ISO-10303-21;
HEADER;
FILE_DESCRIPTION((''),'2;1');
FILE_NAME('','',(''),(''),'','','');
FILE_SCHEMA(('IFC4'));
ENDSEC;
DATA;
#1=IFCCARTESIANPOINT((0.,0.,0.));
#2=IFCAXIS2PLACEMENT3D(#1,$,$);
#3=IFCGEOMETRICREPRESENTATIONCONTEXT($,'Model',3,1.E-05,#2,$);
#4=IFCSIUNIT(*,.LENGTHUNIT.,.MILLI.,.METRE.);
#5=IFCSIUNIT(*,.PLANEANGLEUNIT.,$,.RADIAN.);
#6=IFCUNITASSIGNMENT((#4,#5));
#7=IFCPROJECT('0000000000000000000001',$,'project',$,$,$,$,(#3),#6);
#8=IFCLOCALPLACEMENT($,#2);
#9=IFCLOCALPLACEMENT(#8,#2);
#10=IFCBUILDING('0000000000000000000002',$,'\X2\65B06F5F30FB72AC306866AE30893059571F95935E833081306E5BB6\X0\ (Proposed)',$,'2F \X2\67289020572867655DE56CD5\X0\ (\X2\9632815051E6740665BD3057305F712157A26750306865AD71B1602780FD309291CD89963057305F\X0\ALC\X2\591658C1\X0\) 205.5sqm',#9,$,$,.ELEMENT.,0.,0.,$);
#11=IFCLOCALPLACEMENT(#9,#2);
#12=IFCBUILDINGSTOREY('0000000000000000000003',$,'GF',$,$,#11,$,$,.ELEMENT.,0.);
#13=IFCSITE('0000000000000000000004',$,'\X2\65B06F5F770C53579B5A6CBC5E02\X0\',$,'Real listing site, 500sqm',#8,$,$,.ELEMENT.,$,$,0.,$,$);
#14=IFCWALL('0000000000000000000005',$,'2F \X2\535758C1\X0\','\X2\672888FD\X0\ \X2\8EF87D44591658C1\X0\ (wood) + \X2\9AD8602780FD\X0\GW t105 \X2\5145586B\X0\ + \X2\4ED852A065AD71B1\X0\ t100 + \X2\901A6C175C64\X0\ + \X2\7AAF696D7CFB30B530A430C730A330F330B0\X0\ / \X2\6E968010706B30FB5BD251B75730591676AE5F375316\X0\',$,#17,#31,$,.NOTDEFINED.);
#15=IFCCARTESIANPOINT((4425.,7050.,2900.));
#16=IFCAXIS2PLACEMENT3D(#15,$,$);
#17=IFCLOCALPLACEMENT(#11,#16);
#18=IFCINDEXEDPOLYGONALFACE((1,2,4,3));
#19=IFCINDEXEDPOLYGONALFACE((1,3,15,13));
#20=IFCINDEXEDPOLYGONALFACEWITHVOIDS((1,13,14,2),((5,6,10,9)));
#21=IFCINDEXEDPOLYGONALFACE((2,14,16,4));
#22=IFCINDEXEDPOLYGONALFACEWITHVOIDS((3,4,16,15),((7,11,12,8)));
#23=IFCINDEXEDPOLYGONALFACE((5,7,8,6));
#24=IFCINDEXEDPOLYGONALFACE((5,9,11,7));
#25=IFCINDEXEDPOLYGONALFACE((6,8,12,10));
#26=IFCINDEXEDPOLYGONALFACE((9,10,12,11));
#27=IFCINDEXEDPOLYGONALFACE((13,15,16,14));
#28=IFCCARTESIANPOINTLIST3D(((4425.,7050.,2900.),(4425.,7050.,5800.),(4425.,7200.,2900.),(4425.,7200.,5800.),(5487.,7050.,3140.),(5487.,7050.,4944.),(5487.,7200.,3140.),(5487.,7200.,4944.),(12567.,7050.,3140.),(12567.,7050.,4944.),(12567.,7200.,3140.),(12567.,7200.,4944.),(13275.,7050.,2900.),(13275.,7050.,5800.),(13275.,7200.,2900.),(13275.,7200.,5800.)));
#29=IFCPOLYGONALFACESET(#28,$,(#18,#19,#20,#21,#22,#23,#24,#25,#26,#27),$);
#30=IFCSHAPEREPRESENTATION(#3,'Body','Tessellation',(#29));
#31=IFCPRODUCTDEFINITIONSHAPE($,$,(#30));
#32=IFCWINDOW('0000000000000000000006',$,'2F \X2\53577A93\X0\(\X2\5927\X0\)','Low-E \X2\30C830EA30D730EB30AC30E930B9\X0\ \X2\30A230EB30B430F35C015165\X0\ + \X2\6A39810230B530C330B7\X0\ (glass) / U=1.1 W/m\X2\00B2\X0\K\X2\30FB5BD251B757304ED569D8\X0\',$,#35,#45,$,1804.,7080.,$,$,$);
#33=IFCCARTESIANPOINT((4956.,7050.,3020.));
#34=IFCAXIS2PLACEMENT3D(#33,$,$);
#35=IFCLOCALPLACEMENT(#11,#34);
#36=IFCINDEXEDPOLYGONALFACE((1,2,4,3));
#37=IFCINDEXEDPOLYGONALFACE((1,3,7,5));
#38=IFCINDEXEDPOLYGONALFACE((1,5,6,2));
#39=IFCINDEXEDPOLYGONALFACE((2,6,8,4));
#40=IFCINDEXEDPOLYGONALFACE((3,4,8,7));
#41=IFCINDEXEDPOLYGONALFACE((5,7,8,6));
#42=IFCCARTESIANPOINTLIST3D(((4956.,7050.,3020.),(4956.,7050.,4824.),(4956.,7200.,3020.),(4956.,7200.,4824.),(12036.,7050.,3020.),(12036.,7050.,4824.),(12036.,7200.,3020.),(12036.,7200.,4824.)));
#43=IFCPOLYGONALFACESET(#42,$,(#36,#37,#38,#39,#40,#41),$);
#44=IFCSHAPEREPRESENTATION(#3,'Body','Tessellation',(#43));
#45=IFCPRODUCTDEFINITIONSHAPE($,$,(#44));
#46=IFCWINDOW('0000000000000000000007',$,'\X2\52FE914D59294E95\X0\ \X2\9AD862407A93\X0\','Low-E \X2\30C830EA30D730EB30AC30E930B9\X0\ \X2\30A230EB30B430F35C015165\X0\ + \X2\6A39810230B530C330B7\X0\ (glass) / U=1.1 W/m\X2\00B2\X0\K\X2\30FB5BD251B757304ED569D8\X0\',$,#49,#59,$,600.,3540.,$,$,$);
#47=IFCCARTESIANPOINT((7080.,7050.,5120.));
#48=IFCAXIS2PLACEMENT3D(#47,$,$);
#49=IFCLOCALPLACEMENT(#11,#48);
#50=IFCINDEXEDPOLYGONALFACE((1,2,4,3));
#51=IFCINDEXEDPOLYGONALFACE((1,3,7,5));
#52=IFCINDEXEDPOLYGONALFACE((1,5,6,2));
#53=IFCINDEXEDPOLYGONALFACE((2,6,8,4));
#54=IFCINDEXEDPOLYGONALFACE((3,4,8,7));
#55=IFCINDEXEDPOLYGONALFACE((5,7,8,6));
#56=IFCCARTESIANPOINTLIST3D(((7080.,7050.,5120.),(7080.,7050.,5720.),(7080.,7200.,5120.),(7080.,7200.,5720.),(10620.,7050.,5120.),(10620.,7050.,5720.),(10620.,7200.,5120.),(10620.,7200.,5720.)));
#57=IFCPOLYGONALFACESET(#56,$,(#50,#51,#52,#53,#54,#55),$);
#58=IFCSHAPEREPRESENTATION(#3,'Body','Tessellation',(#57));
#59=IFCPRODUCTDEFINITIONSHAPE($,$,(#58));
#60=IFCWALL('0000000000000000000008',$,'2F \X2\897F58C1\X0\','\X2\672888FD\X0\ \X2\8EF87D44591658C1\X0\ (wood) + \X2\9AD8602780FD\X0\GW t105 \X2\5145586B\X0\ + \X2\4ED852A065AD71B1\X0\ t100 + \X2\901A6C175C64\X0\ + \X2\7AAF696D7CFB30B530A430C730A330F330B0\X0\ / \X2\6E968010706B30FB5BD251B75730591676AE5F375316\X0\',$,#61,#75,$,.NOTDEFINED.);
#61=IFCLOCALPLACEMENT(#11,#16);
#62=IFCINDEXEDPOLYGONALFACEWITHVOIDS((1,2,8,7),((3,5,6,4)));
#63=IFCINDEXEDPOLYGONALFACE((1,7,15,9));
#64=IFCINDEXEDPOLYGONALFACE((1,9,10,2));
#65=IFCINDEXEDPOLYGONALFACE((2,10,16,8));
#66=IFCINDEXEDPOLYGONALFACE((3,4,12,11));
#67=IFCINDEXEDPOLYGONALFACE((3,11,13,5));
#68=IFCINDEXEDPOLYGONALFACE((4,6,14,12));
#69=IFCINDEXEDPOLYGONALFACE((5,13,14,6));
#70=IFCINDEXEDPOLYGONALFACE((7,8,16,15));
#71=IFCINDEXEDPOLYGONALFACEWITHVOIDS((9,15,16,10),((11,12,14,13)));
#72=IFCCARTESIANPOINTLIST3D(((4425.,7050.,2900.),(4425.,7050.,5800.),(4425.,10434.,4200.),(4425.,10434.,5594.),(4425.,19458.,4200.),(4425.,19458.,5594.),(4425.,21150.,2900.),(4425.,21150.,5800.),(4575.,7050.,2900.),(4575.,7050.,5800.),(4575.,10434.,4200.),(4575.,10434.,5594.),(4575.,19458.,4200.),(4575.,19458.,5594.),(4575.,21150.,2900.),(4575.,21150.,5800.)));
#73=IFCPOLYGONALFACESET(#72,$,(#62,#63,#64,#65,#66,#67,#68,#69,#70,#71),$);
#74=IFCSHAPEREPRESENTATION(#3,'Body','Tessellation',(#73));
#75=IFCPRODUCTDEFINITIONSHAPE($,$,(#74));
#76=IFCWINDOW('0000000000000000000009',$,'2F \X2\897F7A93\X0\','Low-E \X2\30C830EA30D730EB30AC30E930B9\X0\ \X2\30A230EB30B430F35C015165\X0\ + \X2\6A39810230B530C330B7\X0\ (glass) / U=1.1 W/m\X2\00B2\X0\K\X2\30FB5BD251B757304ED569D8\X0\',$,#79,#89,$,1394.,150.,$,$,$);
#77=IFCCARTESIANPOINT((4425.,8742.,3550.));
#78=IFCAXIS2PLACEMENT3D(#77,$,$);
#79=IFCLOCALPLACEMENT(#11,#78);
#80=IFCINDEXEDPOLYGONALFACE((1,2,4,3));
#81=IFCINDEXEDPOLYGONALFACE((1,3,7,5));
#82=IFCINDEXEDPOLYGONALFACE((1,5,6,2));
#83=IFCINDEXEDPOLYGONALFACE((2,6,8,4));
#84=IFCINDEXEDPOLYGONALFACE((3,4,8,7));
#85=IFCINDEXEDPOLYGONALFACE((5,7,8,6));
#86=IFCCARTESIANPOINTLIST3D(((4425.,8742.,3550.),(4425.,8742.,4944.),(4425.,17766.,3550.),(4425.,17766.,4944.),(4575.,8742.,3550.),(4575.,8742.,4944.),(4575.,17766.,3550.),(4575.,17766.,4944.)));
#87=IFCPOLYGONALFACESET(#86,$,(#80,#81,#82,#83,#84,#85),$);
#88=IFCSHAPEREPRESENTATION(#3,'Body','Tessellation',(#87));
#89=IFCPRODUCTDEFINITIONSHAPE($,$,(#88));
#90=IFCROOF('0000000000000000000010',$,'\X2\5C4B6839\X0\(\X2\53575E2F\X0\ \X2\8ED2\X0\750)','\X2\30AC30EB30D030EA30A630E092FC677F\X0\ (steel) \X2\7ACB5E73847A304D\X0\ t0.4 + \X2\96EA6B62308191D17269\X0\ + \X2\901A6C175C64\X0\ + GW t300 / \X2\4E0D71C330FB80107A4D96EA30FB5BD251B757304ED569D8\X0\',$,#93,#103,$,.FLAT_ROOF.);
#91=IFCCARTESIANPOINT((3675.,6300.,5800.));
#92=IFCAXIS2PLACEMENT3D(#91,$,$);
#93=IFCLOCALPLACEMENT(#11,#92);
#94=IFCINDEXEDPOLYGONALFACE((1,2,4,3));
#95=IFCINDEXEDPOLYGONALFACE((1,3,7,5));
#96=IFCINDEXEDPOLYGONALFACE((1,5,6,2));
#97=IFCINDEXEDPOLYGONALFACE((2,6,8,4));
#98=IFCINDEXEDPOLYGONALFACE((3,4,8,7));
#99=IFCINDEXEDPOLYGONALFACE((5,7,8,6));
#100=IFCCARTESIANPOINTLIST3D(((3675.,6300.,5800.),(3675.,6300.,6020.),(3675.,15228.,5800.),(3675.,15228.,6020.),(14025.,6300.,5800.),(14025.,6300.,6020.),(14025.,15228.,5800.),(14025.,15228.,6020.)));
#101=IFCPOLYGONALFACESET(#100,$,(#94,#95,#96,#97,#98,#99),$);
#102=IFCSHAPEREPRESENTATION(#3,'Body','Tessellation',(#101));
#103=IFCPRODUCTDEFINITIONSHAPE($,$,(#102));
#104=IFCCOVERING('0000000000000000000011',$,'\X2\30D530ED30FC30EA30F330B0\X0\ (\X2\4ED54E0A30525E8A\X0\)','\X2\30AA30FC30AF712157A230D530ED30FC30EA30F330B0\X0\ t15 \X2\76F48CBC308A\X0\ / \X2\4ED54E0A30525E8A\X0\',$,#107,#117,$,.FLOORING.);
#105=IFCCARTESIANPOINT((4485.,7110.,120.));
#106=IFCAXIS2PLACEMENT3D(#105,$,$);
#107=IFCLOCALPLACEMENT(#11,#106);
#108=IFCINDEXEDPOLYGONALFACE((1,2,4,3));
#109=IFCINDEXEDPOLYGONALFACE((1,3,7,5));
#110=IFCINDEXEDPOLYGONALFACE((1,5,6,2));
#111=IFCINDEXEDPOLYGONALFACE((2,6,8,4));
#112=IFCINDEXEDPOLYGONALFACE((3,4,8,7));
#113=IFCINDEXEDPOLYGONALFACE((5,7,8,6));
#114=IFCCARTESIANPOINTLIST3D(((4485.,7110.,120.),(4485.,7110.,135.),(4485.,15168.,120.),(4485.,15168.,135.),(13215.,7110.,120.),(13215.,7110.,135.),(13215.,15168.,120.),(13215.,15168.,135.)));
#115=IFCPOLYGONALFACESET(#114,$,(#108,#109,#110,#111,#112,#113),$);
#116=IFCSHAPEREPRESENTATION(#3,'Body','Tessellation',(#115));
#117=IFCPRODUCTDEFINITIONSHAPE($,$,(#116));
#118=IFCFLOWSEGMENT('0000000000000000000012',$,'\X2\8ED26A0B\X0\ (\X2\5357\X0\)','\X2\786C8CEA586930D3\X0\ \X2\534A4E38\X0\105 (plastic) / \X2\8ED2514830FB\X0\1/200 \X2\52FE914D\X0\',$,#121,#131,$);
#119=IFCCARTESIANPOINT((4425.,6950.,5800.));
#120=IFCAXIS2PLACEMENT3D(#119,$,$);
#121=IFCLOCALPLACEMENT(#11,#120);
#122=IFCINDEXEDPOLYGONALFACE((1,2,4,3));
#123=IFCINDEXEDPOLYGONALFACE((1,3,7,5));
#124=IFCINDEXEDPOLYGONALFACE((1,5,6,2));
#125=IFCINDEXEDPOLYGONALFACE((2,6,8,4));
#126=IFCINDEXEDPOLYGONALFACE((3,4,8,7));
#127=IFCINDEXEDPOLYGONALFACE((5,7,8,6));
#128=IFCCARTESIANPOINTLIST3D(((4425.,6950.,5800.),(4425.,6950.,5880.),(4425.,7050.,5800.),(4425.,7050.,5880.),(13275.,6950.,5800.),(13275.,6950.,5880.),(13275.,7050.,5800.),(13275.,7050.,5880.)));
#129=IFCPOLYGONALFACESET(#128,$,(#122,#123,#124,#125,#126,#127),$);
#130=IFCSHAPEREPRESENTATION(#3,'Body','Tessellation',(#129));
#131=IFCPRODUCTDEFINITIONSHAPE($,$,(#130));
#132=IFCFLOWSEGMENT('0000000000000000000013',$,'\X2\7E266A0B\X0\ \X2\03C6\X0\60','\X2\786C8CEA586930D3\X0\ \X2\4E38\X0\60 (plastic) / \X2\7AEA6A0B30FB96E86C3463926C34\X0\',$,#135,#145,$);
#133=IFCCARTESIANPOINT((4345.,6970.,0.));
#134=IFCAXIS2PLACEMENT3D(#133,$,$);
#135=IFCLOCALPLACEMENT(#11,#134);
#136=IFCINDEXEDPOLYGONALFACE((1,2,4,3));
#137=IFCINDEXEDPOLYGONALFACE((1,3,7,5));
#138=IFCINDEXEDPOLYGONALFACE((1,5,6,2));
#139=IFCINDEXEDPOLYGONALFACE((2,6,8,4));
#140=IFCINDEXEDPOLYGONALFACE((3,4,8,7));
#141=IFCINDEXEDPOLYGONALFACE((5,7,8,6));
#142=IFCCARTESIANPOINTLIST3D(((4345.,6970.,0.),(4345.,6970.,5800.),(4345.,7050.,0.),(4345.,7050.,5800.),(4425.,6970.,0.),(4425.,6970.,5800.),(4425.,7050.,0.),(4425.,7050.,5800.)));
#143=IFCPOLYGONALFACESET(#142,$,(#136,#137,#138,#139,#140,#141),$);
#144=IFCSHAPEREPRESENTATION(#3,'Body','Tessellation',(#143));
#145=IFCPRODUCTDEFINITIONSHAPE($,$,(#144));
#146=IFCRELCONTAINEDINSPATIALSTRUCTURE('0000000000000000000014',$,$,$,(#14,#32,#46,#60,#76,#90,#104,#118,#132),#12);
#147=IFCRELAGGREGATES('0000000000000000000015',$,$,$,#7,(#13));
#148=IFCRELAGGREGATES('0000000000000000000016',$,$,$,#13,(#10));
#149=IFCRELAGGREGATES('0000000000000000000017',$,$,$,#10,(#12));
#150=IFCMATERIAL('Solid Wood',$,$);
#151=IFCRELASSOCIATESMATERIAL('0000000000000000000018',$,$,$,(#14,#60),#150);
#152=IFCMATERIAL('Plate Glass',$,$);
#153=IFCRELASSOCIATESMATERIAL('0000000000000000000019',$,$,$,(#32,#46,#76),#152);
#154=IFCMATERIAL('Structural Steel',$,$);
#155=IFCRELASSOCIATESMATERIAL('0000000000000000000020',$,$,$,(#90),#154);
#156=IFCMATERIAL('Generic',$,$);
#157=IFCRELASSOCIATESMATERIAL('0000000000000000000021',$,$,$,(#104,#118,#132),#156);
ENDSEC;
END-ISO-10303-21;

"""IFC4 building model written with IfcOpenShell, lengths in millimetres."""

from ifc_helpers import new_model, si_unit, frame, frame_2d, origin, place, context, project, spatial, rectangle, extrude, material, element, fill, save


model = new_model("IFC4")

# Units and contexts
model_context = context("Model", 3, precision=1e-05, world=origin())
ifc_project = project(units=[si_unit("LENGTHUNIT", "METRE", prefix="MILLI"), si_unit("PLANEANGLEUNIT", "RADIAN")], contexts=[model_context])

# Site, building, storey
site_placement = place(None, origin())
site = spatial("IfcSite", under=ifc_project, at=site_placement, Name="新潟県南魚沼市", ObjectType="Real listing site, 500sqm", CompositionType="ELEMENT", RefElevation=0.0)
building_placement = place(site_placement, origin())
building = spatial("IfcBuilding", under=site, at=building_placement, Name="新潟・犬と暮らす土間広めの家 (Proposed)", ObjectType="2F 木造在来工法 (防腐処理施した無垢材と断熱性能を重視したALC外壁) 205.5sqm", CompositionType="ELEMENT", ElevationOfRefHeight=0.0, ElevationOfTerrain=0.0)
storey_placement = place(building_placement, origin())
storey = spatial("IfcBuildingStorey", under=building, at=storey_placement, Name="GF", CompositionType="ELEMENT", Elevation=0.0)

# Shared definitions
ifc_material_1 = material(Name="Solid Wood")

# Shared definitions
ifc_material_2 = material(Name="Plate Glass")

# Wall, openings, windows
wall_1_placement = place(storey_placement, frame((4425.0, 7050.0, 2900.0)))
wall_1 = element("IfcWall", 1, at=wall_1_placement, inside=storey, material=ifc_material_1, Name="2F 南壁", Description="木製 軸組外壁 (wood) + 高性能GW t105 充填 + 付加断熱 t100 + 通気層 + 窯業系サイディング / 準耐火・寒冷地外皮強化", PredefinedType="NOTDEFINED", context=model_context, shape_type="SweptSolid", body=[
    extrude(rectangle(XDim=8850.0, YDim=150.0, at=frame_2d((4425.0, 75.0))), frame((4425.0, 7050.0, 2900.0)), (0.0, 0.0, 1.0), 2900.0),
])
opening_1_placement = place(storey_placement, frame((4956.0, 7050.0, 3020.0)))
opening_1 = element("IfcOpeningElement", 2, at=opening_1_placement, cuts=wall_1, PredefinedType="NOTDEFINED", context=model_context, shape_type="SweptSolid", body=[
    extrude(rectangle(XDim=7080.0, YDim=150.0, at=frame_2d((3540.0, 75.0))), frame((4956.0, 7050.0, 3020.0)), (0.0, 0.0, 1.0), 1804.0),
])
opening_2_placement = place(storey_placement, frame((7080.0, 7050.0, 5120.0)))
opening_2 = element("IfcOpeningElement", 3, at=opening_2_placement, cuts=wall_1, PredefinedType="NOTDEFINED", context=model_context, shape_type="SweptSolid", body=[
    extrude(rectangle(XDim=3540.0, YDim=150.0, at=frame_2d((1770.0, 75.0))), frame((7080.0, 7050.0, 5120.0)), (0.0, 0.0, 1.0), 600.0),
])
window_1_placement = place(storey_placement, frame((4956.0, 7050.0, 3020.0)))
window_1 = element("IfcWindow", 4, at=window_1_placement, inside=storey, material=ifc_material_2, Name="2F 南窓(大)", Description="Low-E トリプルガラス アルゴン封入 + 樹脂サッシ (glass) / U=1.1 W/m²K・寒冷地仕様", OverallHeight=1804.0, OverallWidth=7080.0, context=model_context, shape_type="SweptSolid", body=[
    extrude(rectangle(XDim=7080.0, YDim=150.0, at=frame_2d((3540.0, 75.0))), frame((4956.0, 7050.0, 3020.0)), (0.0, 0.0, 1.0), 1804.0),
])
fill(opening_1, window_1)
window_2_placement = place(storey_placement, frame((7080.0, 7050.0, 5120.0)))
window_2 = element("IfcWindow", 5, at=window_2_placement, inside=storey, material=ifc_material_2, Name="勾配天井 高所窓", Description="Low-E トリプルガラス アルゴン封入 + 樹脂サッシ (glass) / U=1.1 W/m²K・寒冷地仕様", OverallHeight=600.0, OverallWidth=3540.0, context=model_context, shape_type="SweptSolid", body=[
    extrude(rectangle(XDim=3540.0, YDim=150.0, at=frame_2d((1770.0, 75.0))), frame((7080.0, 7050.0, 5120.0)), (0.0, 0.0, 1.0), 600.0),
])
fill(opening_2, window_2)

# Wall, opening, window
wall_2_placement = place(storey_placement, frame((4425.0, 7050.0, 2900.0)))
wall_2 = element("IfcWall", 6, at=wall_2_placement, inside=storey, material=ifc_material_1, Name="2F 西壁", Description="木製 軸組外壁 (wood) + 高性能GW t105 充填 + 付加断熱 t100 + 通気層 + 窯業系サイディング / 準耐火・寒冷地外皮強化", PredefinedType="NOTDEFINED", context=model_context, shape_type="SweptSolid", body=[
    extrude(rectangle(XDim=150.0, YDim=14100.0, at=frame_2d((75.0, 7050.0))), frame((4425.0, 7050.0, 2900.0)), (0.0, 0.0, 1.0), 2900.0),
])
opening_3_placement = place(storey_placement, frame((4425.0, 8742.0, 3550.0)))
opening_3 = element("IfcOpeningElement", 7, at=opening_3_placement, cuts=wall_2, PredefinedType="NOTDEFINED", context=model_context, shape_type="SweptSolid", body=[
    extrude(rectangle(XDim=150.0, YDim=9024.0, at=frame_2d((75.0, 4512.0))), frame((4425.0, 8742.0, 3550.0)), (0.0, 0.0, 1.0), 1394.0),
])
window_3_placement = place(storey_placement, frame((4425.0, 8742.0, 3550.0)))
window_3 = element("IfcWindow", 8, at=window_3_placement, inside=storey, material=ifc_material_2, Name="2F 西窓", Description="Low-E トリプルガラス アルゴン封入 + 樹脂サッシ (glass) / U=1.1 W/m²K・寒冷地仕様", OverallHeight=1394.0, OverallWidth=150.0, context=model_context, shape_type="SweptSolid", body=[
    extrude(rectangle(XDim=150.0, YDim=9024.0, at=frame_2d((75.0, 4512.0))), frame((4425.0, 8742.0, 3550.0)), (0.0, 0.0, 1.0), 1394.0),
])
fill(opening_3, window_3)

# Roof
ifc_material_3 = material(Name="Structural Steel")
for number, where, name in (
    (9, (3675.0, 6300.0, 5800.0), "屋根(南帯 軒750)"),
):
    element("IfcRoof", number, at=place(storey_placement, frame(where)), inside=storey, material=ifc_material_3, Name=name, Description="ガルバリウム鋼板 (steel) 立平葺き t0.4 + 雪止め金物 + 通気層 + GW t300 / 不燃・耐積雪・寒冷地仕様", PredefinedType="FLAT_ROOF", context=model_context, shape_type="SweptSolid", body=[
        extrude(rectangle(XDim=10350.0, YDim=8928.0, at=frame_2d((5175.0, 4464.0))), frame((3675.0, 6300.0, 5800.0)), (0.0, 0.0, 1.0), 220.0),
    ])

# Covering
ifc_material_4 = material(Name="Generic")
covering_placement = place(storey_placement, frame((4485.0, 7110.0, 120.0)))
element("IfcCovering", 10, at=covering_placement, inside=storey, material=ifc_material_4, Name="フローリング (仕上げ床)", Description="オーク無垢フローリング t15 直貼り / 仕上げ床", PredefinedType="FLOORING", context=model_context, shape_type="SweptSolid", body=[
    extrude(rectangle(XDim=8730.0, YDim=8058.0, at=frame_2d((4365.0, 4029.0))), frame((4485.0, 7110.0, 120.0)), (0.0, 0.0, 1.0), 15.0),
])

# Flow segments
flow_segment_1_placement = place(storey_placement, frame((4425.0, 6950.0, 5800.0)))
element("IfcFlowSegment", 11, at=flow_segment_1_placement, inside=storey, material=ifc_material_4, Name="軒樋 (南)", Description="硬質塩ビ 半丸105 (plastic) / 軒先・1/200 勾配", context=model_context, shape_type="SweptSolid", body=[
    extrude(rectangle(XDim=8850.0, YDim=100.0, at=frame_2d((4425.0, 50.0))), frame((4425.0, 6950.0, 5800.0)), (0.0, 0.0, 1.0), 80.0),
])
flow_segment_2_placement = place(storey_placement, frame((4345.0, 6970.0, 0.0)))
element("IfcFlowSegment", 12, at=flow_segment_2_placement, inside=storey, material=ifc_material_4, Name="縦樋 φ60", Description="硬質塩ビ 丸60 (plastic) / 竪樋・雨水排水", context=model_context, shape_type="SweptSolid", body=[
    extrude(rectangle(XDim=80.0, YDim=80.0, at=frame_2d((40.0, 40.0))), frame((4345.0, 6970.0, 0.0)), (0.0, 0.0, 1.0), 5800.0),
])

save(model, "model.ifc")
